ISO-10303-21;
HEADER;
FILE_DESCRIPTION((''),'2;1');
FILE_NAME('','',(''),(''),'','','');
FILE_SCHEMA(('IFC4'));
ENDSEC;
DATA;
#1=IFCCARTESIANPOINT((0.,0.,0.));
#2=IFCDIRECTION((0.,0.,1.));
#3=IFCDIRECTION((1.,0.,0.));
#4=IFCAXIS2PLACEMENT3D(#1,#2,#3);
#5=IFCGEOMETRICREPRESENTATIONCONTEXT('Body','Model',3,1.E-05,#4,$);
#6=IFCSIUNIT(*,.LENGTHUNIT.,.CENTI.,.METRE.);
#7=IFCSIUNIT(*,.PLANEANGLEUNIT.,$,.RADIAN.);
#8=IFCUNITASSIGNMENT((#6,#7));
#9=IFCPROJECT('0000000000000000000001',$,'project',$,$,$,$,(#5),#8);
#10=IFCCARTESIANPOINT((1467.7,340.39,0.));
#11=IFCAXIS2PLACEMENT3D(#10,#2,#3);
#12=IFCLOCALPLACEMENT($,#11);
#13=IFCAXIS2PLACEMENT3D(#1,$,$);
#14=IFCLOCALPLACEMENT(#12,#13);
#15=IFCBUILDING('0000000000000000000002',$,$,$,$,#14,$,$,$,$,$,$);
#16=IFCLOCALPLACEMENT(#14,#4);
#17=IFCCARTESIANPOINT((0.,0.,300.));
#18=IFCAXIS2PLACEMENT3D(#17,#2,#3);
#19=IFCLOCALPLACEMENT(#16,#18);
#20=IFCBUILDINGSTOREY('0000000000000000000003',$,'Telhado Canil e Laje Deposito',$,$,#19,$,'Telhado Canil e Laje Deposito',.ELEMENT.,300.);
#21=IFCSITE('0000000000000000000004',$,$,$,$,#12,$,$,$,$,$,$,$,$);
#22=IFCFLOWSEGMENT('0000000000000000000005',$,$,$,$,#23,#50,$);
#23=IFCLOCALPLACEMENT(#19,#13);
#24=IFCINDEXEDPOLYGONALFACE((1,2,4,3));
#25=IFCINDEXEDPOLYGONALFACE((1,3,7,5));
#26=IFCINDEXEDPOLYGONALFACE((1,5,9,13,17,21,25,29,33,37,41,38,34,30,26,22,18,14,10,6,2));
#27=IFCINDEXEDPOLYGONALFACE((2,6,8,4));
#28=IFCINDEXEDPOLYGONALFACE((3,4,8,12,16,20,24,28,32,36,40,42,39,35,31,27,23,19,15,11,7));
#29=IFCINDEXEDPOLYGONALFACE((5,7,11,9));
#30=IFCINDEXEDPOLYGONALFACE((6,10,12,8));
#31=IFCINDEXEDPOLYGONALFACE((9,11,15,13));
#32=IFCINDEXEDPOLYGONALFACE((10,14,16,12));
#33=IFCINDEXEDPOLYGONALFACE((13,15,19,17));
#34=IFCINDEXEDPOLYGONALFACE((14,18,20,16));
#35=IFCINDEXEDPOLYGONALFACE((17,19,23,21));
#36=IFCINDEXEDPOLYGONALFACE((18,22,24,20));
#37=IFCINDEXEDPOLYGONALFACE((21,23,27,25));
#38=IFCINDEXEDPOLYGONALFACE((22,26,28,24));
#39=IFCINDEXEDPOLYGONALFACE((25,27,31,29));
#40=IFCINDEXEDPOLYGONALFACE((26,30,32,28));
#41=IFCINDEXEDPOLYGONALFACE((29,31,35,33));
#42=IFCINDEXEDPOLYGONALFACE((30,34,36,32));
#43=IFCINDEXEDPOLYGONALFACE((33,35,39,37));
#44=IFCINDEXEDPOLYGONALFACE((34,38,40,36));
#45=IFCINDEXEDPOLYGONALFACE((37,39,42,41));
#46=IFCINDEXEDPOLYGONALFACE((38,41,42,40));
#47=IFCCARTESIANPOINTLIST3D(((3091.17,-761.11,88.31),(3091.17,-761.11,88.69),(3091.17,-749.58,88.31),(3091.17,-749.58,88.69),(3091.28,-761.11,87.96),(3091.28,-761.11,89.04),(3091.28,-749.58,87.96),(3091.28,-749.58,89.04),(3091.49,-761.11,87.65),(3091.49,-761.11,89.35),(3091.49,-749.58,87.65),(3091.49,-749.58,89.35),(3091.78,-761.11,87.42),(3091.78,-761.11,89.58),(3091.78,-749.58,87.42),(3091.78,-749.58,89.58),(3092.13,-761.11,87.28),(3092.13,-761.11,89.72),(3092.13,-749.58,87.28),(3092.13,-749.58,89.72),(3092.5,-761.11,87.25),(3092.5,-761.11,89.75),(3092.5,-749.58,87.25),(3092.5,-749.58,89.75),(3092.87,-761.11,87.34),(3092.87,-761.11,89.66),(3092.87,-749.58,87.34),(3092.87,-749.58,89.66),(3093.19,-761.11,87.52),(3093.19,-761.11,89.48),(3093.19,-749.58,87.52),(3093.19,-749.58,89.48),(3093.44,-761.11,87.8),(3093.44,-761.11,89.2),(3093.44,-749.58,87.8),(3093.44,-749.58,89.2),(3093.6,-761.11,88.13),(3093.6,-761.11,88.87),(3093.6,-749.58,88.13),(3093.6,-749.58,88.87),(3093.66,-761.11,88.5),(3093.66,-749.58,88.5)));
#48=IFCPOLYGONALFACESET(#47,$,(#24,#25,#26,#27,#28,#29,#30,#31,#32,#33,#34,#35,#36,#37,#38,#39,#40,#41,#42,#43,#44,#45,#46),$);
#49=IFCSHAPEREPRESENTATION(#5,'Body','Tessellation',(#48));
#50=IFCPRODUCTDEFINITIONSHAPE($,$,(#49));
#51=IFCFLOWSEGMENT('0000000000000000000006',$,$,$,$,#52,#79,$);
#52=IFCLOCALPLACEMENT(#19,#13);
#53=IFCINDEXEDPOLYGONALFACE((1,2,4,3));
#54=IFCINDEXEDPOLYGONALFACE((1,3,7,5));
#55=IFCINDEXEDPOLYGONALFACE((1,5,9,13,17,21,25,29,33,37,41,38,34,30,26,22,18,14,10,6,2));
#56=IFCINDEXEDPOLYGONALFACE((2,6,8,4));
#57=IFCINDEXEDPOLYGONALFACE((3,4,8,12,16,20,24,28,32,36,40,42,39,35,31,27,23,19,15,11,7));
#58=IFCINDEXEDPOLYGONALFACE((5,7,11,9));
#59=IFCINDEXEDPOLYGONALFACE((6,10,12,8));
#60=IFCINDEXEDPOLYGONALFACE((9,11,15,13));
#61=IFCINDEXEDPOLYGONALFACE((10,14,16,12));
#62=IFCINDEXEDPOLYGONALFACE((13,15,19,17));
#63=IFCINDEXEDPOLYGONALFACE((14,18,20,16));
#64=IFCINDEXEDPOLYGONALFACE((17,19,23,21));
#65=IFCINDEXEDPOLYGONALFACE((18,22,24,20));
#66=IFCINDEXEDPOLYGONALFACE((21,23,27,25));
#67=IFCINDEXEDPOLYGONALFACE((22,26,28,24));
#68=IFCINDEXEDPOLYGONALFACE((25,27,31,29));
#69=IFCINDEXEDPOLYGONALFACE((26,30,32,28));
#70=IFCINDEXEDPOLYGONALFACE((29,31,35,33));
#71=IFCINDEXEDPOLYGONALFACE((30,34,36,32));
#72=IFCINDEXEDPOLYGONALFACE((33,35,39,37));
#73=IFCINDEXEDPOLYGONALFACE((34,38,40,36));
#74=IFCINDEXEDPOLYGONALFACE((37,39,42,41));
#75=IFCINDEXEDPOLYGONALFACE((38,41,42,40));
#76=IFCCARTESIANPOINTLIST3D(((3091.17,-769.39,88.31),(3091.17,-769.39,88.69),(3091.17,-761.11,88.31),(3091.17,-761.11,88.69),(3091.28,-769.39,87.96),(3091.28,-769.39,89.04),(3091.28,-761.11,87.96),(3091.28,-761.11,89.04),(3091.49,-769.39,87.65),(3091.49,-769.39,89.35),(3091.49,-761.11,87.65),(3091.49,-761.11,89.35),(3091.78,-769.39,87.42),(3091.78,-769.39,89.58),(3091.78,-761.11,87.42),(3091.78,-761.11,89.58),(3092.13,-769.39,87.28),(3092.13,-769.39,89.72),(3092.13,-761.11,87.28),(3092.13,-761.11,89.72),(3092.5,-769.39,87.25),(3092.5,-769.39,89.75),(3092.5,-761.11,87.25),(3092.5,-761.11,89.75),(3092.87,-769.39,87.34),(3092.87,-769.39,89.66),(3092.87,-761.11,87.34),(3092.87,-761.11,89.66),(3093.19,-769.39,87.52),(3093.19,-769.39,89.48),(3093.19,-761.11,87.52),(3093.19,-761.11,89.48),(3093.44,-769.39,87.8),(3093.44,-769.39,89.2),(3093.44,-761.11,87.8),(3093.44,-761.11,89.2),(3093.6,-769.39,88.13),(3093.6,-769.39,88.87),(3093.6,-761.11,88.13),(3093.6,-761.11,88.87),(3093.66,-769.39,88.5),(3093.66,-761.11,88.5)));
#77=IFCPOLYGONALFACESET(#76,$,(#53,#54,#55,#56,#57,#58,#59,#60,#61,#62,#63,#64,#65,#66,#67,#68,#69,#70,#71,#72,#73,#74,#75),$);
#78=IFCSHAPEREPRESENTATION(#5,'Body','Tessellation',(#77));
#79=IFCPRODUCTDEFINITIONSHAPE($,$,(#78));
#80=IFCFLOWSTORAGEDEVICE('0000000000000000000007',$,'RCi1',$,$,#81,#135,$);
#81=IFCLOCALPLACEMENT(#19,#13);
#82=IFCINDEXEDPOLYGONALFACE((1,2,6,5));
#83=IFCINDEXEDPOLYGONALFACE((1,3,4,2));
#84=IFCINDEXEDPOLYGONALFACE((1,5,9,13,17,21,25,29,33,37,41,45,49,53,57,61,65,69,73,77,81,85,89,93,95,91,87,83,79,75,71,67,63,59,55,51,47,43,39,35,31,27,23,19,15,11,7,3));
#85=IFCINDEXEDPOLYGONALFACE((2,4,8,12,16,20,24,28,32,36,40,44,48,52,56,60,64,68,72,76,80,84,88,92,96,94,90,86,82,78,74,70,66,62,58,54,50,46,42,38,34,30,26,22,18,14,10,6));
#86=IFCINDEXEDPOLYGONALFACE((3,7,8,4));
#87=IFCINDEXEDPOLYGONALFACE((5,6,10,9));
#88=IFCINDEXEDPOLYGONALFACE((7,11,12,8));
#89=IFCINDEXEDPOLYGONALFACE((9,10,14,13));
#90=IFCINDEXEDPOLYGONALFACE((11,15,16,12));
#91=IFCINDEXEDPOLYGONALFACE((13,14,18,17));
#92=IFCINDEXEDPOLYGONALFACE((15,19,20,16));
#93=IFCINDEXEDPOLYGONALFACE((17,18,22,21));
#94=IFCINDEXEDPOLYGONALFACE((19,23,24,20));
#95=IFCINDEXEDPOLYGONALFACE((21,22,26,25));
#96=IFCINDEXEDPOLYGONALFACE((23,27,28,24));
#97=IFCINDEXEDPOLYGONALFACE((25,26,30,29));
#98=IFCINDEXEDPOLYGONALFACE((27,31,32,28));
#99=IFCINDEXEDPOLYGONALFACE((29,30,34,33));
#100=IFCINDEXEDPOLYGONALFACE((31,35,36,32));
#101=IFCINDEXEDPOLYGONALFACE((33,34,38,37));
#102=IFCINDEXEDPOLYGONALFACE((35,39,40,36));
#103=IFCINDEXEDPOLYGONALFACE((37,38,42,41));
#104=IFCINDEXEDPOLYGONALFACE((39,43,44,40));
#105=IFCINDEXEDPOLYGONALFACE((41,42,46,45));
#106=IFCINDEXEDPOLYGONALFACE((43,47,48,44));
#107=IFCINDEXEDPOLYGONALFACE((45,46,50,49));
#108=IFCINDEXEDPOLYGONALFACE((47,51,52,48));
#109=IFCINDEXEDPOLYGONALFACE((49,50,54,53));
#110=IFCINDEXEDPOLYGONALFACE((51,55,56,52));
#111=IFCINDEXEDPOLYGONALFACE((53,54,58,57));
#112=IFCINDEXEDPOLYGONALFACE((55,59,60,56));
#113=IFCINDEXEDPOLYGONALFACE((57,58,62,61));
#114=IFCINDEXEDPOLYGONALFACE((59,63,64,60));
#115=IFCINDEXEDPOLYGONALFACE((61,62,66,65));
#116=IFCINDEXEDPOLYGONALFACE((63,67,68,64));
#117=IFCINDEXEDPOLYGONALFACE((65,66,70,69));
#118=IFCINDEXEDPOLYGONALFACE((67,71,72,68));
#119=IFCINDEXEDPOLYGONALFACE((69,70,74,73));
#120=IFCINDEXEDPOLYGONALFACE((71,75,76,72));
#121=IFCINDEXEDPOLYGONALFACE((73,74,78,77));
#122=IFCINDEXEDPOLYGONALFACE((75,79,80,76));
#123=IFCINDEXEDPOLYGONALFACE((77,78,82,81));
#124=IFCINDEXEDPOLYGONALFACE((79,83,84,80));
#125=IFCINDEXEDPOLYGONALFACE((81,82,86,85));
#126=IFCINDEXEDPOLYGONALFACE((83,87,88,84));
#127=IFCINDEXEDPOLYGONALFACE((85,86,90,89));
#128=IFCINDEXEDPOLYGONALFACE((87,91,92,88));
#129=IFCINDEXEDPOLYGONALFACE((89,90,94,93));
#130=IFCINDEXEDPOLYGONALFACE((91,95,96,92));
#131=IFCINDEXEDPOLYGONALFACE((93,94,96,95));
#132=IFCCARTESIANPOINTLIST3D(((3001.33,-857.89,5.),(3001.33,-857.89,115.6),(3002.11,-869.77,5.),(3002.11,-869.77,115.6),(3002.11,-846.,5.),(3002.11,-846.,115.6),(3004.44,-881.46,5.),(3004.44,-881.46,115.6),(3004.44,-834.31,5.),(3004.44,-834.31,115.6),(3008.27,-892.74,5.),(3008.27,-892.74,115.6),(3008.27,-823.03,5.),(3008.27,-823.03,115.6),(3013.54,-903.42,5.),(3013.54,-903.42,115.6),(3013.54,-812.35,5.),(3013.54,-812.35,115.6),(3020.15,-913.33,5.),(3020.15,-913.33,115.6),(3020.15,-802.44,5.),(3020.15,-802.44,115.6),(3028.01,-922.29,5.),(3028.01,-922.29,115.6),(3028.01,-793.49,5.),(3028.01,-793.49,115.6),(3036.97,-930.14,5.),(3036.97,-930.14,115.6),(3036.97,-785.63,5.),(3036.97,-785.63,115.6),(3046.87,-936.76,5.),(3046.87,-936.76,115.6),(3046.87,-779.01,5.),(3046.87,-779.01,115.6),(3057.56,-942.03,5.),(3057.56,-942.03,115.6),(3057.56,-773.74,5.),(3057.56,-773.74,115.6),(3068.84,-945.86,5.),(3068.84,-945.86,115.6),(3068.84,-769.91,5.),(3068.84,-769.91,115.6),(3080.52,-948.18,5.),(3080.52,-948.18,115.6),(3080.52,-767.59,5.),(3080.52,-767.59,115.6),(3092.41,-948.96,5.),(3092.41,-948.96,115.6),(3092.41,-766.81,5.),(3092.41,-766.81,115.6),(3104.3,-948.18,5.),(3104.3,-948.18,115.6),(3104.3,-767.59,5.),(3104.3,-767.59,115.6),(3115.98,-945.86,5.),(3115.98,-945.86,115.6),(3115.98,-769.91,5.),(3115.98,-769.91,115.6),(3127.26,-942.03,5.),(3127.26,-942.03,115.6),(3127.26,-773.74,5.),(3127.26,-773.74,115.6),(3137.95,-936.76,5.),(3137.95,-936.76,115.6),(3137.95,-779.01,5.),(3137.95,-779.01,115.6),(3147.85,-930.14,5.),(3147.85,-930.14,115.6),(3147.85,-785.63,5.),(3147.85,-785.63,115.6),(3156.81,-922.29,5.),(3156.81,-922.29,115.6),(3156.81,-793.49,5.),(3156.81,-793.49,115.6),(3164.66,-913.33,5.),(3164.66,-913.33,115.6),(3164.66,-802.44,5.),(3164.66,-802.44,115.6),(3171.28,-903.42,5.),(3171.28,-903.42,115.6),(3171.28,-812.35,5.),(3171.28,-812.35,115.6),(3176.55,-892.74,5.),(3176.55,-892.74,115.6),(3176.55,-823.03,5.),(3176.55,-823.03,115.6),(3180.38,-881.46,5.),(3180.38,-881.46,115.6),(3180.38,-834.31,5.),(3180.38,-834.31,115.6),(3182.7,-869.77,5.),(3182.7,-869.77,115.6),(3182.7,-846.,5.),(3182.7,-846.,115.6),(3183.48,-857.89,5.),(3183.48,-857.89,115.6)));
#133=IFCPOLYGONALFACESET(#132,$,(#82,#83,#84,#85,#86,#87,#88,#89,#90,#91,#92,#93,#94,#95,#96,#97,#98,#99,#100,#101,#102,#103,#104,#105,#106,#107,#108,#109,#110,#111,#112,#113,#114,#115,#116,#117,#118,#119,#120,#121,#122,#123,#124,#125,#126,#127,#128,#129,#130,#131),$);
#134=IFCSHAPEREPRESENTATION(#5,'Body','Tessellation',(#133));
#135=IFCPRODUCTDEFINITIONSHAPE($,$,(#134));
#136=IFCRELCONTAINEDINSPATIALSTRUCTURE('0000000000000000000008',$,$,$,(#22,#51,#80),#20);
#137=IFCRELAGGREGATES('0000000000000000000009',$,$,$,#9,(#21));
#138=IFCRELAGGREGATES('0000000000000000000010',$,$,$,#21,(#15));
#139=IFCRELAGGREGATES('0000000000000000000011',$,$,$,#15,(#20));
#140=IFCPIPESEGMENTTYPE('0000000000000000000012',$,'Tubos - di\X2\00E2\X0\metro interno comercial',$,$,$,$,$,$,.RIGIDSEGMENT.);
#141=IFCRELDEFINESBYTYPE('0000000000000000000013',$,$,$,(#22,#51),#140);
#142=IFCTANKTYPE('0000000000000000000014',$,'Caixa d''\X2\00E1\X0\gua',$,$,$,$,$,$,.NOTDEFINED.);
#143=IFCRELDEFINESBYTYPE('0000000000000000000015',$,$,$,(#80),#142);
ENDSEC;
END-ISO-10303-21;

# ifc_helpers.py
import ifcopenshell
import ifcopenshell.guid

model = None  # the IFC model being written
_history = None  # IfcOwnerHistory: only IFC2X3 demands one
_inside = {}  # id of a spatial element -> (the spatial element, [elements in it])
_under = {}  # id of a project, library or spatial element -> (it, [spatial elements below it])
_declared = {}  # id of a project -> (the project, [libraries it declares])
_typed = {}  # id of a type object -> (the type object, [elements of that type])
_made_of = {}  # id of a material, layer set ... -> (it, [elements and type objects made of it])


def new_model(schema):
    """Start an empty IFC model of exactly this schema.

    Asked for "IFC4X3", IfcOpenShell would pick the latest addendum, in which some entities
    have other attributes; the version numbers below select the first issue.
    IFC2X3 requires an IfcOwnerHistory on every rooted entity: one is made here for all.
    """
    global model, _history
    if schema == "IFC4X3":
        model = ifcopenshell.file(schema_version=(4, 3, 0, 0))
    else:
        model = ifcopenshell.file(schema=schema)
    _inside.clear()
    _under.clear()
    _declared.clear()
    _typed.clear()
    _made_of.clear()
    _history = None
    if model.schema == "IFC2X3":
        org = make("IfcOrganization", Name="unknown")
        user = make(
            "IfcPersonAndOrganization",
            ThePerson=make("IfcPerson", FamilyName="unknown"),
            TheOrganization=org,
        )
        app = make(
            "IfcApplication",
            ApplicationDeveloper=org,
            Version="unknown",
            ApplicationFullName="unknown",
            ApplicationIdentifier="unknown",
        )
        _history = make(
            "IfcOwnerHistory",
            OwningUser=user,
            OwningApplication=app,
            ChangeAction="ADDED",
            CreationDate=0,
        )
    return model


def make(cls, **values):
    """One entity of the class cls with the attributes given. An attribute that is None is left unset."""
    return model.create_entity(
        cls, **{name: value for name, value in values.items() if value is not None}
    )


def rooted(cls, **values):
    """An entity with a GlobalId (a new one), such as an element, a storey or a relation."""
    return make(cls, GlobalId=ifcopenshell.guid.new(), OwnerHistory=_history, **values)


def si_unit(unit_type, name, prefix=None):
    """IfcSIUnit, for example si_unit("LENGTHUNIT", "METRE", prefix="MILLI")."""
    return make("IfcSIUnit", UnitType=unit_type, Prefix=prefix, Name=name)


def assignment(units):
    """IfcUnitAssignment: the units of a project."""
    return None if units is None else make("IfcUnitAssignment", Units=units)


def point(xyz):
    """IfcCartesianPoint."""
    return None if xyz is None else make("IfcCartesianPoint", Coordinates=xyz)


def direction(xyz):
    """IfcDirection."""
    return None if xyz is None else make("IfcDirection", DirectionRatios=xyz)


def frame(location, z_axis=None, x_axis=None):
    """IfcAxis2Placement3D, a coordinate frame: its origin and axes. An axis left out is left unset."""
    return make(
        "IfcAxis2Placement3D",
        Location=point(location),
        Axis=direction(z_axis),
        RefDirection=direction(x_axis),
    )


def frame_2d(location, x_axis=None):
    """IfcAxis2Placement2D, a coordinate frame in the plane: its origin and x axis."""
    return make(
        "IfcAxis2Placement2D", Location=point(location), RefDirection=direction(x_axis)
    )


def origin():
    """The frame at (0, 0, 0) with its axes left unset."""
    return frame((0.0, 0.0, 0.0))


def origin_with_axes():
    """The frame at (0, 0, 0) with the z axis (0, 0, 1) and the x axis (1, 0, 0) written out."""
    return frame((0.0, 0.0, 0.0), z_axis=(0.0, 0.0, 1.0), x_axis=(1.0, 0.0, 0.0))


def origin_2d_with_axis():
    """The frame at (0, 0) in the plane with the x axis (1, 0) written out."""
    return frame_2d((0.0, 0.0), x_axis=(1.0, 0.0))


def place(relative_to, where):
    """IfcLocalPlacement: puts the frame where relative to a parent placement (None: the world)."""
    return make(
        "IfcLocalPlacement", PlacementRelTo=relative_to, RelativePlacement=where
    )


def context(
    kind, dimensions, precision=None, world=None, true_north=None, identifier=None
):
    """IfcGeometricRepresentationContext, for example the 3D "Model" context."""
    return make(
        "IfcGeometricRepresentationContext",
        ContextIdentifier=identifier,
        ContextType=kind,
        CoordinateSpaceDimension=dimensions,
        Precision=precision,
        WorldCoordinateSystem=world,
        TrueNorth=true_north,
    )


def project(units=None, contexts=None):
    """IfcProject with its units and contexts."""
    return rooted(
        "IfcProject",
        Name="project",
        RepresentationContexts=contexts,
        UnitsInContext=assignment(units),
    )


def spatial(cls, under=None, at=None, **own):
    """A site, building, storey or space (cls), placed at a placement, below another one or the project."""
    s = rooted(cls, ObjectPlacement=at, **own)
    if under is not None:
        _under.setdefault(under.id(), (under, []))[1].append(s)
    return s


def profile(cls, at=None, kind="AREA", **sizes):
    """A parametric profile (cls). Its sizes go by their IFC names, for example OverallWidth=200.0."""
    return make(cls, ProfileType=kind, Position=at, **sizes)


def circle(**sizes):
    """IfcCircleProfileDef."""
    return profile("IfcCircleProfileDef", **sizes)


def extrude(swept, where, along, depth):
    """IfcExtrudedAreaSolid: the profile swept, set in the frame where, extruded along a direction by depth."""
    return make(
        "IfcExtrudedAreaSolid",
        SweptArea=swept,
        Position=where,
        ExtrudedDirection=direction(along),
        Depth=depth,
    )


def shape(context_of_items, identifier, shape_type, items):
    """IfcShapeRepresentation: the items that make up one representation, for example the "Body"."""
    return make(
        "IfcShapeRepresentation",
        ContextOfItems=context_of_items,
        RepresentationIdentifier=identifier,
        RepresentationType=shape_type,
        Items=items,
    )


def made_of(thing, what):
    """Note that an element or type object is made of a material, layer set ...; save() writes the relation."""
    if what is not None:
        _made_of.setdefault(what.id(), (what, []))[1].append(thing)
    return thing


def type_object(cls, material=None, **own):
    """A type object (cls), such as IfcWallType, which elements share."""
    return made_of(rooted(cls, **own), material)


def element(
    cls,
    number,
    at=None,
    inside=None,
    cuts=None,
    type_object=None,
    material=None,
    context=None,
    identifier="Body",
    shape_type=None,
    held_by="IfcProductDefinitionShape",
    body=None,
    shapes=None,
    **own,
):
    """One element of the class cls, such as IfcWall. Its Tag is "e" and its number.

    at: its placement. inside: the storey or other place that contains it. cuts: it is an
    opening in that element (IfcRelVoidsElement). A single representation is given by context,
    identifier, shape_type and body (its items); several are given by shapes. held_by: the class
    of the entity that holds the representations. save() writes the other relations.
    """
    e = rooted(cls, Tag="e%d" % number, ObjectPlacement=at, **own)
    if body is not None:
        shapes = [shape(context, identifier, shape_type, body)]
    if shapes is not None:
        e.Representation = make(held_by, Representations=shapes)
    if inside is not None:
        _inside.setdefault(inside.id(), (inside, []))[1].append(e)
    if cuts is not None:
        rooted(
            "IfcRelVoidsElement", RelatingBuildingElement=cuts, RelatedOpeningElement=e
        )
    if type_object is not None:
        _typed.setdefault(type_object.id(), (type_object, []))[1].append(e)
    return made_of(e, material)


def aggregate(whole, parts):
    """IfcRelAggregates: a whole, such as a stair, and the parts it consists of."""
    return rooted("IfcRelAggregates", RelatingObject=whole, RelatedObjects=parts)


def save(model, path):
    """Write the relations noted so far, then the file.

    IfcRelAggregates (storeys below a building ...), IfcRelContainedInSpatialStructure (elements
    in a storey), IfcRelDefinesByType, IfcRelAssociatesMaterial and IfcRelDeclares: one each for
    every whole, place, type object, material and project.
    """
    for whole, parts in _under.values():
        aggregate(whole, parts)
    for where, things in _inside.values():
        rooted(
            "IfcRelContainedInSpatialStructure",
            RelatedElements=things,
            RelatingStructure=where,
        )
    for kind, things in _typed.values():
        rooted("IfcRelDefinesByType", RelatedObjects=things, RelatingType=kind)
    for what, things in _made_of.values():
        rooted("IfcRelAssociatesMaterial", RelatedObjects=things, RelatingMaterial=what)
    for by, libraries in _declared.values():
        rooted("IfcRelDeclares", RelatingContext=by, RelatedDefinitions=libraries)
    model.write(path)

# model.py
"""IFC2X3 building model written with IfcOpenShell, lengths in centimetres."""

from ifc_helpers import new_model, si_unit, frame, origin, origin_with_axes, origin_2d_with_axis, place, context, project, spatial, circle, extrude, type_object, element, save


model = new_model("IFC2X3")

# Units and contexts
model_context = context("Model", 3, precision=1e-05, world=origin_with_axes(), identifier="Body")
ifc_project = project(units=[si_unit("LENGTHUNIT", "METRE", prefix="CENTI"), si_unit("PLANEANGLEUNIT", "RADIAN")], contexts=[model_context])

# Site, building, storey
site_placement = place(None, frame((1467.7, 340.39, 0.0), z_axis=(0.0, 0.0, 1.0), x_axis=(1.0, 0.0, 0.0)))
site = spatial("IfcSite", under=ifc_project, at=site_placement)
building_placement = place(site_placement, origin())
building = spatial("IfcBuilding", under=site, at=building_placement)
placement = place(building_placement, origin_with_axes())
storey_placement = place(placement, frame((0.0, 0.0, 300.0), z_axis=(0.0, 0.0, 1.0), x_axis=(1.0, 0.0, 0.0)))
storey = spatial("IfcBuildingStorey", under=building, at=storey_placement, Name="Telhado Canil e Laje Deposito", LongName="Telhado Canil e Laje Deposito", CompositionType="ELEMENT", Elevation=300.0)

# Flow segments
pipe_segment_type = type_object("IfcPipeSegmentType", Name="Tubos - diâmetro interno comercial", PredefinedType="RIGIDSEGMENT")
flow_segment_1_placement = place(storey_placement, frame((3092.41, -755.34, 89.75), z_axis=(0.0, 0.0, 1.0), x_axis=(1.0, 0.0, 0.0)))
element("IfcFlowSegment", 1, at=flow_segment_1_placement, inside=storey, type_object=pipe_segment_type, context=model_context, shape_type="SolidModel", body=[
    extrude(circle(Radius=1.25, at=origin_2d_with_axis()), frame((0.0, 5.76, -1.25), z_axis=(0.0, -1.0, 0.0), x_axis=(1.0, 0.0, 0.0)), (0.0, 0.0, 1.0), 11.53),
])
flow_segment_2_placement = place(storey_placement, frame((3092.41, -765.25, 89.75), z_axis=(0.0, 0.0, 1.0), x_axis=(1.0, 0.0, 0.0)))
element("IfcFlowSegment", 2, at=flow_segment_2_placement, inside=storey, type_object=pipe_segment_type, context=model_context, shape_type="SolidModel", body=[
    extrude(circle(Radius=1.25, at=origin_2d_with_axis()), frame((0.0, 4.14, -1.25), z_axis=(0.0, -1.0, 0.0), x_axis=(1.0, 0.0, 0.0)), (0.0, 0.0, 1.0), 8.28),
])

# Flow storage device
tank_type = type_object("IfcTankType", Name="Caixa d'água")
flow_storage_device_placement = place(storey_placement, frame((3092.41, -857.89, 115.6), z_axis=(0.0, 0.0, 1.0), x_axis=(1.0, 0.0, 0.0)))
element("IfcFlowStorageDevice", 3, at=flow_storage_device_placement, inside=storey, type_object=tank_type, Name="RCi1", context=model_context, shape_type="SolidModel", body=[
    extrude(circle(Radius=91.08, at=origin_2d_with_axis()), frame((0.0, 0.0, 0.0), z_axis=(0.0, 0.0, -1.0), x_axis=(1.0, 0.0, 0.0)), (0.0, 0.0, 1.0), 110.6),
])

save(model, "model.ifc")
